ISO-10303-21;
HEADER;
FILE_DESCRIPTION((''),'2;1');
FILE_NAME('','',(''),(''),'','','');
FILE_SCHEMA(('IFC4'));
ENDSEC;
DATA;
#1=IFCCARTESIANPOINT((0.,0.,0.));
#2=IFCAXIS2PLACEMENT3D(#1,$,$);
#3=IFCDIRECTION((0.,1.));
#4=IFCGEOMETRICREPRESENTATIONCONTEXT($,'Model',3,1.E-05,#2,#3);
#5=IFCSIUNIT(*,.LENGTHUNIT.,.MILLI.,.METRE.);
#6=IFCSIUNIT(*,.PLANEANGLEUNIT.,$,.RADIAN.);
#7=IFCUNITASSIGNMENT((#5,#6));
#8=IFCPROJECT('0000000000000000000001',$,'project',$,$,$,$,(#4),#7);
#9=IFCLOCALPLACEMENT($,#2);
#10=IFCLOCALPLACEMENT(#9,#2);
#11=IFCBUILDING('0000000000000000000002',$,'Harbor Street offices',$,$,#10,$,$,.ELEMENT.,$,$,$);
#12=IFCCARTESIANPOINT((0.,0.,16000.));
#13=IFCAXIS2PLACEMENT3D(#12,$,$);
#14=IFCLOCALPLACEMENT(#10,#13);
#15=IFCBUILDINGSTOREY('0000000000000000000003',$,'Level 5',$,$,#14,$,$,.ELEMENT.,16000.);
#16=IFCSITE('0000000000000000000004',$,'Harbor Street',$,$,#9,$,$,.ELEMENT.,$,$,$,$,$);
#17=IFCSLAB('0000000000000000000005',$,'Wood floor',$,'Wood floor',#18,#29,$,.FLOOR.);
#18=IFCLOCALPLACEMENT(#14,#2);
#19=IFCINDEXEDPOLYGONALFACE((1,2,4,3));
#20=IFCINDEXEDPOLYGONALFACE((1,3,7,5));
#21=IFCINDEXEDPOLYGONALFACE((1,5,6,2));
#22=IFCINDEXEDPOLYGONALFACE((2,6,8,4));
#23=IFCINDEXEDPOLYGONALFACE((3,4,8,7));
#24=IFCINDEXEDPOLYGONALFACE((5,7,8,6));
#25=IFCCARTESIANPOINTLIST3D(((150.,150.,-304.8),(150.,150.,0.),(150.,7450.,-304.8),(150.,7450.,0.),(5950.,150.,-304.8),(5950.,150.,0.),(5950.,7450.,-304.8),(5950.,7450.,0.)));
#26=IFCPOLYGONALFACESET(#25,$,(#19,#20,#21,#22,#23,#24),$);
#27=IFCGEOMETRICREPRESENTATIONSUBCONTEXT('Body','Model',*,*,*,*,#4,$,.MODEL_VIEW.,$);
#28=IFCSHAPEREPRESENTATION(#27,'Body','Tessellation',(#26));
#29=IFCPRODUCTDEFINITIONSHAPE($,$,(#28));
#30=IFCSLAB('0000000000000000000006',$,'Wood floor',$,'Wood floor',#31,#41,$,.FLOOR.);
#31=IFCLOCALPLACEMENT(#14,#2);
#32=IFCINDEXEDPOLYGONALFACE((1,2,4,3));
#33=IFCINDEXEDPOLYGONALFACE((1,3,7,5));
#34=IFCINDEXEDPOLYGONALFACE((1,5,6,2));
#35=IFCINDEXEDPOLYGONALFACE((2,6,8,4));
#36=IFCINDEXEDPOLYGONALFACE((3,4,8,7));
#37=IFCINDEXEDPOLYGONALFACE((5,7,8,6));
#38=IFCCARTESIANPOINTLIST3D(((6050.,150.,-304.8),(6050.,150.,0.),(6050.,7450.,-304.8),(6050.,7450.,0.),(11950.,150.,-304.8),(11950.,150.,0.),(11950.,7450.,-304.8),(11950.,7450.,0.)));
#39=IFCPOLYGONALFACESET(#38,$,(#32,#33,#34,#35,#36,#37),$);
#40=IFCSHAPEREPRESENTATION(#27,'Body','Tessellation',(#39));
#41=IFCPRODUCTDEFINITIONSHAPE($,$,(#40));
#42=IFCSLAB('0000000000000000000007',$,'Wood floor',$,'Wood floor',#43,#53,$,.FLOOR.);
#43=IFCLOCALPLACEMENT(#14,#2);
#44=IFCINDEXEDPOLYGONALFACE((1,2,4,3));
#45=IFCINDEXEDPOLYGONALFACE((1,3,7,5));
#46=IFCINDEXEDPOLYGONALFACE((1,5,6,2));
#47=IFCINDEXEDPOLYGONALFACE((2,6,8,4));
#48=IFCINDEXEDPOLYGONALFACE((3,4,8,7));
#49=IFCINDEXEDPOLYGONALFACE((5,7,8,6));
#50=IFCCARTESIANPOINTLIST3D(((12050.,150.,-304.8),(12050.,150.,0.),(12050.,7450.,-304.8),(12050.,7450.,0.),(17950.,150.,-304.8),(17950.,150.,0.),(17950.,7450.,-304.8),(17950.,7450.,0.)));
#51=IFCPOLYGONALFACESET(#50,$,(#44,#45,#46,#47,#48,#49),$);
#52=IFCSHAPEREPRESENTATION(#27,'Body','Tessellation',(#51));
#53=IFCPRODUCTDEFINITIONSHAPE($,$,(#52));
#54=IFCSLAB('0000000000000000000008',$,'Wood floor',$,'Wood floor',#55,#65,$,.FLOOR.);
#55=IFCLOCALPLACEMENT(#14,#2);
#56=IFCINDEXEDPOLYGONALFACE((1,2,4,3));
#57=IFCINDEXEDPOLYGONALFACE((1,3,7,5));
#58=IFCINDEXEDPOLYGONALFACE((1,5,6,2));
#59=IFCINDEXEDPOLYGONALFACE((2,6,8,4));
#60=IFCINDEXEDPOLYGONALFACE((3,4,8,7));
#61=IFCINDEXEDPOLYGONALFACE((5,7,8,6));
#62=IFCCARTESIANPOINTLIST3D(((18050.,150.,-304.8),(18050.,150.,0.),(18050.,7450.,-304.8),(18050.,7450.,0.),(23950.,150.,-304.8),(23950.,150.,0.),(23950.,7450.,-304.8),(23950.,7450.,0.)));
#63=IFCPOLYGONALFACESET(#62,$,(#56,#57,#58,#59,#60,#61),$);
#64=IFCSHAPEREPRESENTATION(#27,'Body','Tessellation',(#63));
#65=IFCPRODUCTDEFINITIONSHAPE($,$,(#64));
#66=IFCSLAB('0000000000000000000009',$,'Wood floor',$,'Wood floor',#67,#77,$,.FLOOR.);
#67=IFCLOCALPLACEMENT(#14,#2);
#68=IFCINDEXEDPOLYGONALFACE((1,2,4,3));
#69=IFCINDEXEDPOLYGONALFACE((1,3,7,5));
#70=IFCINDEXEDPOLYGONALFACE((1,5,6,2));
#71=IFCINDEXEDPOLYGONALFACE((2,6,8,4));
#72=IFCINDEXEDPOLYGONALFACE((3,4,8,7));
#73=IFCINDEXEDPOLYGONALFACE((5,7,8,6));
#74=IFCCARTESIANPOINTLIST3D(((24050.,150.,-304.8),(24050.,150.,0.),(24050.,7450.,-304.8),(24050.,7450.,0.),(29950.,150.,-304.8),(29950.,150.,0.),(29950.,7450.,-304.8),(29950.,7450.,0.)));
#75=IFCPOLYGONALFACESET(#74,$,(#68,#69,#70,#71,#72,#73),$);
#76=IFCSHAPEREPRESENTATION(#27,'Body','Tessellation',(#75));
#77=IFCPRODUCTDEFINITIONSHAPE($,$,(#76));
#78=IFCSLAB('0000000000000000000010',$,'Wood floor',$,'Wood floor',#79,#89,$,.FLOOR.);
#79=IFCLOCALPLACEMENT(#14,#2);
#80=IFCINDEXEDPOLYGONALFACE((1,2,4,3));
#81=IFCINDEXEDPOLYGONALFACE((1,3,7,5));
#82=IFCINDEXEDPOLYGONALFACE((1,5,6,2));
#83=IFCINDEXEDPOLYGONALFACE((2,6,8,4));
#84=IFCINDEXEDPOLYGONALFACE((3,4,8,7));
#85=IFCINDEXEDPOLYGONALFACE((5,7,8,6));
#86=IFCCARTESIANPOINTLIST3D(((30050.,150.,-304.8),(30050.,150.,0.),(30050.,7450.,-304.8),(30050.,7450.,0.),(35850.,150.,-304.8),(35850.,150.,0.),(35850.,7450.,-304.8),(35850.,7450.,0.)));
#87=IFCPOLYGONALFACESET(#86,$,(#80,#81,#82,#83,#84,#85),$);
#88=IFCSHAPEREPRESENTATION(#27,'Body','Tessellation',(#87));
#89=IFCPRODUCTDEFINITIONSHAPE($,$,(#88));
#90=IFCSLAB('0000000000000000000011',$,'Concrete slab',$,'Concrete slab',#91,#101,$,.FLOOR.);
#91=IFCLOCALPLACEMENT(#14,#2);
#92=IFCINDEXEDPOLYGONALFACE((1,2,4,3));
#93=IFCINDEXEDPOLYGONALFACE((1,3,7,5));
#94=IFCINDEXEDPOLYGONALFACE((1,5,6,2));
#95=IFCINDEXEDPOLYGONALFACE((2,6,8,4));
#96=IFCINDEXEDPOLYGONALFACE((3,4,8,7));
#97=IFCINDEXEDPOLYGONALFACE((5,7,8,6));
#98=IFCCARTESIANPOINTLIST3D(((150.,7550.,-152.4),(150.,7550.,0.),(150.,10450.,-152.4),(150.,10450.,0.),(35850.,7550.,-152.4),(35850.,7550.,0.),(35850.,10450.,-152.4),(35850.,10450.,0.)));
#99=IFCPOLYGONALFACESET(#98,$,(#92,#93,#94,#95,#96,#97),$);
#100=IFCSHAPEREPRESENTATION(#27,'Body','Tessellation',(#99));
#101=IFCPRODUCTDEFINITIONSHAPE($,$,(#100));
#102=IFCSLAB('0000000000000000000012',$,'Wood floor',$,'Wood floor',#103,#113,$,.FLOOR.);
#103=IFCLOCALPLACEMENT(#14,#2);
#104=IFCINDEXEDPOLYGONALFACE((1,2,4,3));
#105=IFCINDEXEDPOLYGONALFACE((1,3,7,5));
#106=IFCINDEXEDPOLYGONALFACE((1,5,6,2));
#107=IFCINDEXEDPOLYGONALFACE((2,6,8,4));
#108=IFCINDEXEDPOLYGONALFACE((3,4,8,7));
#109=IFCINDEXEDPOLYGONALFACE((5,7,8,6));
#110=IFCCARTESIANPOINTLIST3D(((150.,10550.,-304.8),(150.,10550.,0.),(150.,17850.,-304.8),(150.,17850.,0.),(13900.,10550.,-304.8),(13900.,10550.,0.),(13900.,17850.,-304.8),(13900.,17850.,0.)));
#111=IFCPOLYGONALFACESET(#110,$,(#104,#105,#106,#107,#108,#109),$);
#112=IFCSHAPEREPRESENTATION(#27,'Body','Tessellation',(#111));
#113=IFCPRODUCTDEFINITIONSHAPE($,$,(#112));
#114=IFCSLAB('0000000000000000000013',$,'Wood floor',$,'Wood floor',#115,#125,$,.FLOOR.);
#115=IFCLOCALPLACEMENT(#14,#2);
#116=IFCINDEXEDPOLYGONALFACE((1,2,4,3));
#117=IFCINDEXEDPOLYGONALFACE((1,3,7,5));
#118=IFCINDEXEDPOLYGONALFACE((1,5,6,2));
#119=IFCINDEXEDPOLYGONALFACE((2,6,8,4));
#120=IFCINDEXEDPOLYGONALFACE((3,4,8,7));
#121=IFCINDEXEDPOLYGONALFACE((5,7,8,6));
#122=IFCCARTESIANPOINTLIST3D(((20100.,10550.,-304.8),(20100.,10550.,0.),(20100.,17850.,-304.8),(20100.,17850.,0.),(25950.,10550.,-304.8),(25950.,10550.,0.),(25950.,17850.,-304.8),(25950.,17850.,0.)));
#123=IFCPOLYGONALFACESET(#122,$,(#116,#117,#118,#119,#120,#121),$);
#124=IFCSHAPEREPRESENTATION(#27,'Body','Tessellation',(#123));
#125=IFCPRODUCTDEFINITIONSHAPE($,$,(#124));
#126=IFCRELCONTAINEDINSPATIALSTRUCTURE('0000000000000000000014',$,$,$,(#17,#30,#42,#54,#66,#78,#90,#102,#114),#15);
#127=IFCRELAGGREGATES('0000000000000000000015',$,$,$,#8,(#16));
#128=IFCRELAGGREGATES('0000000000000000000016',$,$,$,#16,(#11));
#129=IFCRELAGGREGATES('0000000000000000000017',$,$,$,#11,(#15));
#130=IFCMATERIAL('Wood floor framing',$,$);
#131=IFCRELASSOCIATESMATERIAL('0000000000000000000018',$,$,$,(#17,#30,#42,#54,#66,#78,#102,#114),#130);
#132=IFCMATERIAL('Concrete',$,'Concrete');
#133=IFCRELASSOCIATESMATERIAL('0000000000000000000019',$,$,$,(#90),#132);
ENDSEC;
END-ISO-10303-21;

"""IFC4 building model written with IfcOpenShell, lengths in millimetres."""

from ifc_helpers import new_model, si_unit, direction, frame, origin, origin_with_axes, place, context, subcontext, project, spatial, polyline, outline, extrude, material, element, save


model = new_model("IFC4")

# Units and contexts
model_context = context("Model", 3, precision=1e-05, world=origin(), true_north=direction((0.0, 1.0)))
body_context = subcontext(model_context, "Body", "Model", "MODEL_VIEW")
ifc_project = project(units=[si_unit("LENGTHUNIT", "METRE", prefix="MILLI"), si_unit("PLANEANGLEUNIT", "RADIAN")], contexts=[model_context])

# Site, building, storey
site_placement = place(None, origin())
site = spatial("IfcSite", under=ifc_project, at=site_placement, Name="Harbor Street", CompositionType="ELEMENT")
building_placement = place(site_placement, origin())
building = spatial("IfcBuilding", under=site, at=building_placement, Name="Harbor Street offices", CompositionType="ELEMENT")
storey_placement = place(building_placement, frame((0.0, 0.0, 16000.0)))
storey = spatial("IfcBuildingStorey", under=building, at=storey_placement, Name="Level 5", CompositionType="ELEMENT", Elevation=16000.0)

# Slabs
ifc_material_1 = material(Name="Wood floor framing")
slab_1_placement = place(storey_placement, origin_with_axes())
element("IfcSlab", 1, at=slab_1_placement, inside=storey, material=ifc_material_1, Name="Wood floor", ObjectType="Wood floor", PredefinedType="FLOOR", context=body_context, shape_type="SweptSolid", body=[
    extrude(outline(polyline([(150.0, 150.0), (5950.0, 150.0), (5950.0, 7450.0), (150.0, 7450.0), (150.0, 150.0)])), frame((0.0, 0.0, -304.8)), (0.0, 0.0, 1.0), 304.8),
])
slab_2_placement = place(storey_placement, origin_with_axes())
element("IfcSlab", 2, at=slab_2_placement, inside=storey, material=ifc_material_1, Name="Wood floor", ObjectType="Wood floor", PredefinedType="FLOOR", context=body_context, shape_type="SweptSolid", body=[
    extrude(outline(polyline([(6050.0, 150.0), (11950.0, 150.0), (11950.0, 7450.0), (6050.0, 7450.0), (6050.0, 150.0)])), frame((0.0, 0.0, -304.8)), (0.0, 0.0, 1.0), 304.8),
])
slab_3_placement = place(storey_placement, origin_with_axes())
element("IfcSlab", 3, at=slab_3_placement, inside=storey, material=ifc_material_1, Name="Wood floor", ObjectType="Wood floor", PredefinedType="FLOOR", context=body_context, shape_type="SweptSolid", body=[
    extrude(outline(polyline([(12050.0, 150.0), (17950.0, 150.0), (17950.0, 7450.0), (12050.0, 7450.0), (12050.0, 150.0)])), frame((0.0, 0.0, -304.8)), (0.0, 0.0, 1.0), 304.8),
])
slab_4_placement = place(storey_placement, origin_with_axes())
element("IfcSlab", 4, at=slab_4_placement, inside=storey, material=ifc_material_1, Name="Wood floor", ObjectType="Wood floor", PredefinedType="FLOOR", context=body_context, shape_type="SweptSolid", body=[
    extrude(outline(polyline([(18050.0, 150.0), (23950.0, 150.0), (23950.0, 7450.0), (18050.0, 7450.0), (18050.0, 150.0)])), frame((0.0, 0.0, -304.8)), (0.0, 0.0, 1.0), 304.8),
])
slab_5_placement = place(storey_placement, origin_with_axes())
element("IfcSlab", 5, at=slab_5_placement, inside=storey, material=ifc_material_1, Name="Wood floor", ObjectType="Wood floor", PredefinedType="FLOOR", context=body_context, shape_type="SweptSolid", body=[
    extrude(outline(polyline([(24050.0, 150.0), (29950.0, 150.0), (29950.0, 7450.0), (24050.0, 7450.0), (24050.0, 150.0)])), frame((0.0, 0.0, -304.8)), (0.0, 0.0, 1.0), 304.8),
])
slab_6_placement = place(storey_placement, origin_with_axes())
element("IfcSlab", 6, at=slab_6_placement, inside=storey, material=ifc_material_1, Name="Wood floor", ObjectType="Wood floor", PredefinedType="FLOOR", context=body_context, shape_type="SweptSolid", body=[
    extrude(outline(polyline([(30050.0, 150.0), (35850.0, 150.0), (35850.0, 7450.0), (30050.0, 7450.0), (30050.0, 150.0)])), frame((0.0, 0.0, -304.8)), (0.0, 0.0, 1.0), 304.8),
])
ifc_material_2 = material(Name="Concrete", Category="Concrete")
slab_7_placement = place(storey_placement, origin_with_axes())
element("IfcSlab", 7, at=slab_7_placement, inside=storey, material=ifc_material_2, Name="Concrete slab", ObjectType="Concrete slab", PredefinedType="FLOOR", context=body_context, shape_type="SweptSolid", body=[
    extrude(outline(polyline([(35850.0, 7550.0), (35850.0, 10450.0), (150.0, 10450.0), (150.0, 7550.0), (35850.0, 7550.0)])), frame((0.0, 0.0, -152.4)), (0.0, 0.0, 1.0), 152.4),
])
slab_8_placement = place(storey_placement, origin_with_axes())
element("IfcSlab", 8, at=slab_8_placement, inside=storey, material=ifc_material_1, Name="Wood floor", ObjectType="Wood floor", PredefinedType="FLOOR", context=body_context, shape_type="SweptSolid", body=[
    extrude(outline(polyline([(13900.0, 17850.0), (150.0, 17850.0), (150.0, 10550.0), (13900.0, 10550.0), (13900.0, 17850.0)])), frame((0.0, 0.0, -304.8)), (0.0, 0.0, 1.0), 304.8),
])
slab_9_placement = place(storey_placement, origin_with_axes())
element("IfcSlab", 9, at=slab_9_placement, inside=storey, material=ifc_material_1, Name="Wood floor", ObjectType="Wood floor", PredefinedType="FLOOR", context=body_context, shape_type="SweptSolid", body=[
    extrude(outline(polyline([(25950.0, 17850.0), (20100.0, 17850.0), (20100.0, 10550.0), (25950.0, 10550.0), (25950.0, 17850.0)])), frame((0.0, 0.0, -304.8)), (0.0, 0.0, 1.0), 304.8),
])

save(model, "model.ifc")
